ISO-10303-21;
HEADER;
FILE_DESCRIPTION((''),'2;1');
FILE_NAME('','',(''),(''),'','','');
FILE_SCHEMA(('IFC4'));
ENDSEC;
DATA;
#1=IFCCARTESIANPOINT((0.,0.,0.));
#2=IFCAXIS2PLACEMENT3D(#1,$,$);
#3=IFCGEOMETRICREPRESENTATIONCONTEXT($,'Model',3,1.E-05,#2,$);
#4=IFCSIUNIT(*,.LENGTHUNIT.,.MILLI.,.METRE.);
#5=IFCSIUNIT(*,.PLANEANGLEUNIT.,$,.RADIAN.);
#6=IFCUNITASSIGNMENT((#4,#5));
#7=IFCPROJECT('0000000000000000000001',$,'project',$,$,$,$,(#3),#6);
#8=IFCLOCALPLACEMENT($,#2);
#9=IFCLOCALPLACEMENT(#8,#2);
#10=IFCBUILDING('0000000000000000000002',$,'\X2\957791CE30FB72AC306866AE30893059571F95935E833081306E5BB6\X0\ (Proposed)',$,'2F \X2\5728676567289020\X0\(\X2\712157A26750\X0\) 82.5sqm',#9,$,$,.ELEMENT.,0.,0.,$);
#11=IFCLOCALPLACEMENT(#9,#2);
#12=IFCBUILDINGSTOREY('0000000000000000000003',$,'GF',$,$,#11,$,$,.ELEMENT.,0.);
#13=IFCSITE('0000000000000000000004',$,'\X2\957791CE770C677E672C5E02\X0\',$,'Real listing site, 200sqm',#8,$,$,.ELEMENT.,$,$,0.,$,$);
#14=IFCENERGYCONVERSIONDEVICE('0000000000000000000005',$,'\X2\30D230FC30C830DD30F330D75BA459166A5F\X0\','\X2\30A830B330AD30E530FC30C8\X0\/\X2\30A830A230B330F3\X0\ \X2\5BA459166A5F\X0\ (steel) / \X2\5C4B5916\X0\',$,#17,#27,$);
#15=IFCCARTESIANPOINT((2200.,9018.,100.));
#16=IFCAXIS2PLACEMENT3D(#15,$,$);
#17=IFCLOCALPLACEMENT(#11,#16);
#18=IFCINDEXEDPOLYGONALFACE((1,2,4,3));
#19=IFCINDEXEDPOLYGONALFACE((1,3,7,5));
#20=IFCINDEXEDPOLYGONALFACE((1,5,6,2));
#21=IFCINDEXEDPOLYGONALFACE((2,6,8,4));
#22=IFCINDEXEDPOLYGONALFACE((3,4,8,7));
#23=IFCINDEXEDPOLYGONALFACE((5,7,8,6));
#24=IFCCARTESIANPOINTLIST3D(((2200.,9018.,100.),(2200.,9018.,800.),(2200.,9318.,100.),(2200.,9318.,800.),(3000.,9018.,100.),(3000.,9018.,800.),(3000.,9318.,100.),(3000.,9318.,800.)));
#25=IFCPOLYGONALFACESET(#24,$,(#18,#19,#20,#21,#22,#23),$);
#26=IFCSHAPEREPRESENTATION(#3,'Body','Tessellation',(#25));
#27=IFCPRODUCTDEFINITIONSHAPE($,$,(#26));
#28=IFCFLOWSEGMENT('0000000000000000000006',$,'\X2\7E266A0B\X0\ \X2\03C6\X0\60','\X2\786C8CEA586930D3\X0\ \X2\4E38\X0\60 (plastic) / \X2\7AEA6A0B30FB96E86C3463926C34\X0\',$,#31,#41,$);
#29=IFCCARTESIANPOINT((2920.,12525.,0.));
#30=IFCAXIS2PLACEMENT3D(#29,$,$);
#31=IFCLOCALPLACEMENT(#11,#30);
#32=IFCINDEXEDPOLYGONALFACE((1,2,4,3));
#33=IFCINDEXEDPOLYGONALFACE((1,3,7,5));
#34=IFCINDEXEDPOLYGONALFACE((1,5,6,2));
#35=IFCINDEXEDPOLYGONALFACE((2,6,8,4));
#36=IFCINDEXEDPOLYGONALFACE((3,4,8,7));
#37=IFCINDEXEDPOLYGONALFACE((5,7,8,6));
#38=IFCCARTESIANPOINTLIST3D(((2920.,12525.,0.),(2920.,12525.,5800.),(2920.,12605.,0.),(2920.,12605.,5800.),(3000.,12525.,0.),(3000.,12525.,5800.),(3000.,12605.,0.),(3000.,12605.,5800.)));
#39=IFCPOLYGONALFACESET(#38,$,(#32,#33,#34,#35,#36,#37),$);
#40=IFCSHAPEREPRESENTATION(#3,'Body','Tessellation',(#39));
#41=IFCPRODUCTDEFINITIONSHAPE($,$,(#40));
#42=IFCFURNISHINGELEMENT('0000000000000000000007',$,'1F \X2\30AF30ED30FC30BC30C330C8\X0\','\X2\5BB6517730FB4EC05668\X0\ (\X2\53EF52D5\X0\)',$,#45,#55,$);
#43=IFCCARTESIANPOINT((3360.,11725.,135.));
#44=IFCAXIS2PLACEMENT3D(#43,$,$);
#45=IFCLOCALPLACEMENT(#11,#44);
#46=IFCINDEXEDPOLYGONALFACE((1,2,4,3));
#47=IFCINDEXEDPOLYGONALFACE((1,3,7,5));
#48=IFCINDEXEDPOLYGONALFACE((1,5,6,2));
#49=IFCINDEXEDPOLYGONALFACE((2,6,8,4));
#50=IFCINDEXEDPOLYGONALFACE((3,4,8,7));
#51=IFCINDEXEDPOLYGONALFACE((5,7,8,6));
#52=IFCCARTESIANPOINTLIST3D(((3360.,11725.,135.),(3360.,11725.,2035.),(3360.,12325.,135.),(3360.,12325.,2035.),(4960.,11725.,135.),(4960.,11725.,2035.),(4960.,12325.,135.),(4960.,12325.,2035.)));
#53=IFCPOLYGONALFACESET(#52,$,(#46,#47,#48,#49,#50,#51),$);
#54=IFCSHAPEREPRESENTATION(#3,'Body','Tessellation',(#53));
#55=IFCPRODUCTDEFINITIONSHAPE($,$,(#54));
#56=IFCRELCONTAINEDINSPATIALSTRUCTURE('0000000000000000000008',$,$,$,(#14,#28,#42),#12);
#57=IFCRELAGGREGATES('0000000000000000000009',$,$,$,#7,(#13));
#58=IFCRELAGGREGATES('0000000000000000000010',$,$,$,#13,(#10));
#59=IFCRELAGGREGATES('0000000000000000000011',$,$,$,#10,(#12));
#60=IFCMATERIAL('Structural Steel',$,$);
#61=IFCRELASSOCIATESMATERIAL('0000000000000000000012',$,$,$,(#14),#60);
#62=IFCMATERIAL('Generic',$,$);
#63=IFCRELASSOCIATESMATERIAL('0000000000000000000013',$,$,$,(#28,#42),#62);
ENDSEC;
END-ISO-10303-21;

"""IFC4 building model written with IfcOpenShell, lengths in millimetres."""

from ifc_helpers import new_model, si_unit, frame, frame_2d, origin, place, context, project, spatial, rectangle, extrude, material, element, save


model = new_model("IFC4")

# Units and contexts
model_context = context("Model", 3, precision=1e-05, world=origin())
ifc_project = project(units=[si_unit("LENGTHUNIT", "METRE", prefix="MILLI"), si_unit("PLANEANGLEUNIT", "RADIAN")], contexts=[model_context])

# Site, building, storey
site_placement = place(None, origin())
site = spatial("IfcSite", under=ifc_project, at=site_placement, Name="長野県松本市", ObjectType="Real listing site, 200sqm", CompositionType="ELEMENT", RefElevation=0.0)
building_placement = place(site_placement, origin())
building = spatial("IfcBuilding", under=site, at=building_placement, Name="長野・犬と暮らす土間広めの家 (Proposed)", ObjectType="2F 在来木造(無垢材) 82.5sqm", CompositionType="ELEMENT", ElevationOfRefHeight=0.0, ElevationOfTerrain=0.0)
storey_placement = place(building_placement, origin())
storey = spatial("IfcBuildingStorey", under=building, at=storey_placement, Name="GF", CompositionType="ELEMENT", Elevation=0.0)

# Shared definitions
ifc_material_1 = material(Name="Generic")

# Energy conversion device
ifc_material_2 = material(Name="Structural Steel")
energy_conversion_device_placement = place(storey_placement, frame((2200.0, 9018.0, 100.0)))
element("IfcEnergyConversionDevice", 1, at=energy_conversion_device_placement, inside=storey, material=ifc_material_2, Name="ヒートポンプ室外機", Description="エコキュート/エアコン 室外機 (steel) / 屋外", context=model_context, shape_type="SweptSolid", body=[
    extrude(rectangle(XDim=800.0, YDim=300.0, at=frame_2d((400.0, 150.0))), frame((2200.0, 9018.0, 100.0)), (0.0, 0.0, 1.0), 700.0),
])

# Flow segment
flow_segment_placement = place(storey_placement, frame((2920.0, 12525.0, 0.0)))
element("IfcFlowSegment", 2, at=flow_segment_placement, inside=storey, material=ifc_material_1, Name="縦樋 φ60", Description="硬質塩ビ 丸60 (plastic) / 竪樋・雨水排水", context=model_context, shape_type="SweptSolid", body=[
    extrude(rectangle(XDim=80.0, YDim=80.0, at=frame_2d((40.0, 40.0))), frame((2920.0, 12525.0, 0.0)), (0.0, 0.0, 1.0), 5800.0),
])

# Furnishing element
furnishing_placement = place(storey_placement, frame((3360.0, 11725.0, 135.0)))
element("IfcFurnishingElement", 3, at=furnishing_placement, inside=storey, material=ifc_material_1, Name="1F クローゼット", Description="家具・什器 (可動)", context=model_context, shape_type="SweptSolid", body=[
    extrude(rectangle(XDim=1600.0, YDim=600.0, at=frame_2d((800.0, 300.0))), frame((3360.0, 11725.0, 135.0)), (0.0, 0.0, 1.0), 1900.0),
])

save(model, "model.ifc")
